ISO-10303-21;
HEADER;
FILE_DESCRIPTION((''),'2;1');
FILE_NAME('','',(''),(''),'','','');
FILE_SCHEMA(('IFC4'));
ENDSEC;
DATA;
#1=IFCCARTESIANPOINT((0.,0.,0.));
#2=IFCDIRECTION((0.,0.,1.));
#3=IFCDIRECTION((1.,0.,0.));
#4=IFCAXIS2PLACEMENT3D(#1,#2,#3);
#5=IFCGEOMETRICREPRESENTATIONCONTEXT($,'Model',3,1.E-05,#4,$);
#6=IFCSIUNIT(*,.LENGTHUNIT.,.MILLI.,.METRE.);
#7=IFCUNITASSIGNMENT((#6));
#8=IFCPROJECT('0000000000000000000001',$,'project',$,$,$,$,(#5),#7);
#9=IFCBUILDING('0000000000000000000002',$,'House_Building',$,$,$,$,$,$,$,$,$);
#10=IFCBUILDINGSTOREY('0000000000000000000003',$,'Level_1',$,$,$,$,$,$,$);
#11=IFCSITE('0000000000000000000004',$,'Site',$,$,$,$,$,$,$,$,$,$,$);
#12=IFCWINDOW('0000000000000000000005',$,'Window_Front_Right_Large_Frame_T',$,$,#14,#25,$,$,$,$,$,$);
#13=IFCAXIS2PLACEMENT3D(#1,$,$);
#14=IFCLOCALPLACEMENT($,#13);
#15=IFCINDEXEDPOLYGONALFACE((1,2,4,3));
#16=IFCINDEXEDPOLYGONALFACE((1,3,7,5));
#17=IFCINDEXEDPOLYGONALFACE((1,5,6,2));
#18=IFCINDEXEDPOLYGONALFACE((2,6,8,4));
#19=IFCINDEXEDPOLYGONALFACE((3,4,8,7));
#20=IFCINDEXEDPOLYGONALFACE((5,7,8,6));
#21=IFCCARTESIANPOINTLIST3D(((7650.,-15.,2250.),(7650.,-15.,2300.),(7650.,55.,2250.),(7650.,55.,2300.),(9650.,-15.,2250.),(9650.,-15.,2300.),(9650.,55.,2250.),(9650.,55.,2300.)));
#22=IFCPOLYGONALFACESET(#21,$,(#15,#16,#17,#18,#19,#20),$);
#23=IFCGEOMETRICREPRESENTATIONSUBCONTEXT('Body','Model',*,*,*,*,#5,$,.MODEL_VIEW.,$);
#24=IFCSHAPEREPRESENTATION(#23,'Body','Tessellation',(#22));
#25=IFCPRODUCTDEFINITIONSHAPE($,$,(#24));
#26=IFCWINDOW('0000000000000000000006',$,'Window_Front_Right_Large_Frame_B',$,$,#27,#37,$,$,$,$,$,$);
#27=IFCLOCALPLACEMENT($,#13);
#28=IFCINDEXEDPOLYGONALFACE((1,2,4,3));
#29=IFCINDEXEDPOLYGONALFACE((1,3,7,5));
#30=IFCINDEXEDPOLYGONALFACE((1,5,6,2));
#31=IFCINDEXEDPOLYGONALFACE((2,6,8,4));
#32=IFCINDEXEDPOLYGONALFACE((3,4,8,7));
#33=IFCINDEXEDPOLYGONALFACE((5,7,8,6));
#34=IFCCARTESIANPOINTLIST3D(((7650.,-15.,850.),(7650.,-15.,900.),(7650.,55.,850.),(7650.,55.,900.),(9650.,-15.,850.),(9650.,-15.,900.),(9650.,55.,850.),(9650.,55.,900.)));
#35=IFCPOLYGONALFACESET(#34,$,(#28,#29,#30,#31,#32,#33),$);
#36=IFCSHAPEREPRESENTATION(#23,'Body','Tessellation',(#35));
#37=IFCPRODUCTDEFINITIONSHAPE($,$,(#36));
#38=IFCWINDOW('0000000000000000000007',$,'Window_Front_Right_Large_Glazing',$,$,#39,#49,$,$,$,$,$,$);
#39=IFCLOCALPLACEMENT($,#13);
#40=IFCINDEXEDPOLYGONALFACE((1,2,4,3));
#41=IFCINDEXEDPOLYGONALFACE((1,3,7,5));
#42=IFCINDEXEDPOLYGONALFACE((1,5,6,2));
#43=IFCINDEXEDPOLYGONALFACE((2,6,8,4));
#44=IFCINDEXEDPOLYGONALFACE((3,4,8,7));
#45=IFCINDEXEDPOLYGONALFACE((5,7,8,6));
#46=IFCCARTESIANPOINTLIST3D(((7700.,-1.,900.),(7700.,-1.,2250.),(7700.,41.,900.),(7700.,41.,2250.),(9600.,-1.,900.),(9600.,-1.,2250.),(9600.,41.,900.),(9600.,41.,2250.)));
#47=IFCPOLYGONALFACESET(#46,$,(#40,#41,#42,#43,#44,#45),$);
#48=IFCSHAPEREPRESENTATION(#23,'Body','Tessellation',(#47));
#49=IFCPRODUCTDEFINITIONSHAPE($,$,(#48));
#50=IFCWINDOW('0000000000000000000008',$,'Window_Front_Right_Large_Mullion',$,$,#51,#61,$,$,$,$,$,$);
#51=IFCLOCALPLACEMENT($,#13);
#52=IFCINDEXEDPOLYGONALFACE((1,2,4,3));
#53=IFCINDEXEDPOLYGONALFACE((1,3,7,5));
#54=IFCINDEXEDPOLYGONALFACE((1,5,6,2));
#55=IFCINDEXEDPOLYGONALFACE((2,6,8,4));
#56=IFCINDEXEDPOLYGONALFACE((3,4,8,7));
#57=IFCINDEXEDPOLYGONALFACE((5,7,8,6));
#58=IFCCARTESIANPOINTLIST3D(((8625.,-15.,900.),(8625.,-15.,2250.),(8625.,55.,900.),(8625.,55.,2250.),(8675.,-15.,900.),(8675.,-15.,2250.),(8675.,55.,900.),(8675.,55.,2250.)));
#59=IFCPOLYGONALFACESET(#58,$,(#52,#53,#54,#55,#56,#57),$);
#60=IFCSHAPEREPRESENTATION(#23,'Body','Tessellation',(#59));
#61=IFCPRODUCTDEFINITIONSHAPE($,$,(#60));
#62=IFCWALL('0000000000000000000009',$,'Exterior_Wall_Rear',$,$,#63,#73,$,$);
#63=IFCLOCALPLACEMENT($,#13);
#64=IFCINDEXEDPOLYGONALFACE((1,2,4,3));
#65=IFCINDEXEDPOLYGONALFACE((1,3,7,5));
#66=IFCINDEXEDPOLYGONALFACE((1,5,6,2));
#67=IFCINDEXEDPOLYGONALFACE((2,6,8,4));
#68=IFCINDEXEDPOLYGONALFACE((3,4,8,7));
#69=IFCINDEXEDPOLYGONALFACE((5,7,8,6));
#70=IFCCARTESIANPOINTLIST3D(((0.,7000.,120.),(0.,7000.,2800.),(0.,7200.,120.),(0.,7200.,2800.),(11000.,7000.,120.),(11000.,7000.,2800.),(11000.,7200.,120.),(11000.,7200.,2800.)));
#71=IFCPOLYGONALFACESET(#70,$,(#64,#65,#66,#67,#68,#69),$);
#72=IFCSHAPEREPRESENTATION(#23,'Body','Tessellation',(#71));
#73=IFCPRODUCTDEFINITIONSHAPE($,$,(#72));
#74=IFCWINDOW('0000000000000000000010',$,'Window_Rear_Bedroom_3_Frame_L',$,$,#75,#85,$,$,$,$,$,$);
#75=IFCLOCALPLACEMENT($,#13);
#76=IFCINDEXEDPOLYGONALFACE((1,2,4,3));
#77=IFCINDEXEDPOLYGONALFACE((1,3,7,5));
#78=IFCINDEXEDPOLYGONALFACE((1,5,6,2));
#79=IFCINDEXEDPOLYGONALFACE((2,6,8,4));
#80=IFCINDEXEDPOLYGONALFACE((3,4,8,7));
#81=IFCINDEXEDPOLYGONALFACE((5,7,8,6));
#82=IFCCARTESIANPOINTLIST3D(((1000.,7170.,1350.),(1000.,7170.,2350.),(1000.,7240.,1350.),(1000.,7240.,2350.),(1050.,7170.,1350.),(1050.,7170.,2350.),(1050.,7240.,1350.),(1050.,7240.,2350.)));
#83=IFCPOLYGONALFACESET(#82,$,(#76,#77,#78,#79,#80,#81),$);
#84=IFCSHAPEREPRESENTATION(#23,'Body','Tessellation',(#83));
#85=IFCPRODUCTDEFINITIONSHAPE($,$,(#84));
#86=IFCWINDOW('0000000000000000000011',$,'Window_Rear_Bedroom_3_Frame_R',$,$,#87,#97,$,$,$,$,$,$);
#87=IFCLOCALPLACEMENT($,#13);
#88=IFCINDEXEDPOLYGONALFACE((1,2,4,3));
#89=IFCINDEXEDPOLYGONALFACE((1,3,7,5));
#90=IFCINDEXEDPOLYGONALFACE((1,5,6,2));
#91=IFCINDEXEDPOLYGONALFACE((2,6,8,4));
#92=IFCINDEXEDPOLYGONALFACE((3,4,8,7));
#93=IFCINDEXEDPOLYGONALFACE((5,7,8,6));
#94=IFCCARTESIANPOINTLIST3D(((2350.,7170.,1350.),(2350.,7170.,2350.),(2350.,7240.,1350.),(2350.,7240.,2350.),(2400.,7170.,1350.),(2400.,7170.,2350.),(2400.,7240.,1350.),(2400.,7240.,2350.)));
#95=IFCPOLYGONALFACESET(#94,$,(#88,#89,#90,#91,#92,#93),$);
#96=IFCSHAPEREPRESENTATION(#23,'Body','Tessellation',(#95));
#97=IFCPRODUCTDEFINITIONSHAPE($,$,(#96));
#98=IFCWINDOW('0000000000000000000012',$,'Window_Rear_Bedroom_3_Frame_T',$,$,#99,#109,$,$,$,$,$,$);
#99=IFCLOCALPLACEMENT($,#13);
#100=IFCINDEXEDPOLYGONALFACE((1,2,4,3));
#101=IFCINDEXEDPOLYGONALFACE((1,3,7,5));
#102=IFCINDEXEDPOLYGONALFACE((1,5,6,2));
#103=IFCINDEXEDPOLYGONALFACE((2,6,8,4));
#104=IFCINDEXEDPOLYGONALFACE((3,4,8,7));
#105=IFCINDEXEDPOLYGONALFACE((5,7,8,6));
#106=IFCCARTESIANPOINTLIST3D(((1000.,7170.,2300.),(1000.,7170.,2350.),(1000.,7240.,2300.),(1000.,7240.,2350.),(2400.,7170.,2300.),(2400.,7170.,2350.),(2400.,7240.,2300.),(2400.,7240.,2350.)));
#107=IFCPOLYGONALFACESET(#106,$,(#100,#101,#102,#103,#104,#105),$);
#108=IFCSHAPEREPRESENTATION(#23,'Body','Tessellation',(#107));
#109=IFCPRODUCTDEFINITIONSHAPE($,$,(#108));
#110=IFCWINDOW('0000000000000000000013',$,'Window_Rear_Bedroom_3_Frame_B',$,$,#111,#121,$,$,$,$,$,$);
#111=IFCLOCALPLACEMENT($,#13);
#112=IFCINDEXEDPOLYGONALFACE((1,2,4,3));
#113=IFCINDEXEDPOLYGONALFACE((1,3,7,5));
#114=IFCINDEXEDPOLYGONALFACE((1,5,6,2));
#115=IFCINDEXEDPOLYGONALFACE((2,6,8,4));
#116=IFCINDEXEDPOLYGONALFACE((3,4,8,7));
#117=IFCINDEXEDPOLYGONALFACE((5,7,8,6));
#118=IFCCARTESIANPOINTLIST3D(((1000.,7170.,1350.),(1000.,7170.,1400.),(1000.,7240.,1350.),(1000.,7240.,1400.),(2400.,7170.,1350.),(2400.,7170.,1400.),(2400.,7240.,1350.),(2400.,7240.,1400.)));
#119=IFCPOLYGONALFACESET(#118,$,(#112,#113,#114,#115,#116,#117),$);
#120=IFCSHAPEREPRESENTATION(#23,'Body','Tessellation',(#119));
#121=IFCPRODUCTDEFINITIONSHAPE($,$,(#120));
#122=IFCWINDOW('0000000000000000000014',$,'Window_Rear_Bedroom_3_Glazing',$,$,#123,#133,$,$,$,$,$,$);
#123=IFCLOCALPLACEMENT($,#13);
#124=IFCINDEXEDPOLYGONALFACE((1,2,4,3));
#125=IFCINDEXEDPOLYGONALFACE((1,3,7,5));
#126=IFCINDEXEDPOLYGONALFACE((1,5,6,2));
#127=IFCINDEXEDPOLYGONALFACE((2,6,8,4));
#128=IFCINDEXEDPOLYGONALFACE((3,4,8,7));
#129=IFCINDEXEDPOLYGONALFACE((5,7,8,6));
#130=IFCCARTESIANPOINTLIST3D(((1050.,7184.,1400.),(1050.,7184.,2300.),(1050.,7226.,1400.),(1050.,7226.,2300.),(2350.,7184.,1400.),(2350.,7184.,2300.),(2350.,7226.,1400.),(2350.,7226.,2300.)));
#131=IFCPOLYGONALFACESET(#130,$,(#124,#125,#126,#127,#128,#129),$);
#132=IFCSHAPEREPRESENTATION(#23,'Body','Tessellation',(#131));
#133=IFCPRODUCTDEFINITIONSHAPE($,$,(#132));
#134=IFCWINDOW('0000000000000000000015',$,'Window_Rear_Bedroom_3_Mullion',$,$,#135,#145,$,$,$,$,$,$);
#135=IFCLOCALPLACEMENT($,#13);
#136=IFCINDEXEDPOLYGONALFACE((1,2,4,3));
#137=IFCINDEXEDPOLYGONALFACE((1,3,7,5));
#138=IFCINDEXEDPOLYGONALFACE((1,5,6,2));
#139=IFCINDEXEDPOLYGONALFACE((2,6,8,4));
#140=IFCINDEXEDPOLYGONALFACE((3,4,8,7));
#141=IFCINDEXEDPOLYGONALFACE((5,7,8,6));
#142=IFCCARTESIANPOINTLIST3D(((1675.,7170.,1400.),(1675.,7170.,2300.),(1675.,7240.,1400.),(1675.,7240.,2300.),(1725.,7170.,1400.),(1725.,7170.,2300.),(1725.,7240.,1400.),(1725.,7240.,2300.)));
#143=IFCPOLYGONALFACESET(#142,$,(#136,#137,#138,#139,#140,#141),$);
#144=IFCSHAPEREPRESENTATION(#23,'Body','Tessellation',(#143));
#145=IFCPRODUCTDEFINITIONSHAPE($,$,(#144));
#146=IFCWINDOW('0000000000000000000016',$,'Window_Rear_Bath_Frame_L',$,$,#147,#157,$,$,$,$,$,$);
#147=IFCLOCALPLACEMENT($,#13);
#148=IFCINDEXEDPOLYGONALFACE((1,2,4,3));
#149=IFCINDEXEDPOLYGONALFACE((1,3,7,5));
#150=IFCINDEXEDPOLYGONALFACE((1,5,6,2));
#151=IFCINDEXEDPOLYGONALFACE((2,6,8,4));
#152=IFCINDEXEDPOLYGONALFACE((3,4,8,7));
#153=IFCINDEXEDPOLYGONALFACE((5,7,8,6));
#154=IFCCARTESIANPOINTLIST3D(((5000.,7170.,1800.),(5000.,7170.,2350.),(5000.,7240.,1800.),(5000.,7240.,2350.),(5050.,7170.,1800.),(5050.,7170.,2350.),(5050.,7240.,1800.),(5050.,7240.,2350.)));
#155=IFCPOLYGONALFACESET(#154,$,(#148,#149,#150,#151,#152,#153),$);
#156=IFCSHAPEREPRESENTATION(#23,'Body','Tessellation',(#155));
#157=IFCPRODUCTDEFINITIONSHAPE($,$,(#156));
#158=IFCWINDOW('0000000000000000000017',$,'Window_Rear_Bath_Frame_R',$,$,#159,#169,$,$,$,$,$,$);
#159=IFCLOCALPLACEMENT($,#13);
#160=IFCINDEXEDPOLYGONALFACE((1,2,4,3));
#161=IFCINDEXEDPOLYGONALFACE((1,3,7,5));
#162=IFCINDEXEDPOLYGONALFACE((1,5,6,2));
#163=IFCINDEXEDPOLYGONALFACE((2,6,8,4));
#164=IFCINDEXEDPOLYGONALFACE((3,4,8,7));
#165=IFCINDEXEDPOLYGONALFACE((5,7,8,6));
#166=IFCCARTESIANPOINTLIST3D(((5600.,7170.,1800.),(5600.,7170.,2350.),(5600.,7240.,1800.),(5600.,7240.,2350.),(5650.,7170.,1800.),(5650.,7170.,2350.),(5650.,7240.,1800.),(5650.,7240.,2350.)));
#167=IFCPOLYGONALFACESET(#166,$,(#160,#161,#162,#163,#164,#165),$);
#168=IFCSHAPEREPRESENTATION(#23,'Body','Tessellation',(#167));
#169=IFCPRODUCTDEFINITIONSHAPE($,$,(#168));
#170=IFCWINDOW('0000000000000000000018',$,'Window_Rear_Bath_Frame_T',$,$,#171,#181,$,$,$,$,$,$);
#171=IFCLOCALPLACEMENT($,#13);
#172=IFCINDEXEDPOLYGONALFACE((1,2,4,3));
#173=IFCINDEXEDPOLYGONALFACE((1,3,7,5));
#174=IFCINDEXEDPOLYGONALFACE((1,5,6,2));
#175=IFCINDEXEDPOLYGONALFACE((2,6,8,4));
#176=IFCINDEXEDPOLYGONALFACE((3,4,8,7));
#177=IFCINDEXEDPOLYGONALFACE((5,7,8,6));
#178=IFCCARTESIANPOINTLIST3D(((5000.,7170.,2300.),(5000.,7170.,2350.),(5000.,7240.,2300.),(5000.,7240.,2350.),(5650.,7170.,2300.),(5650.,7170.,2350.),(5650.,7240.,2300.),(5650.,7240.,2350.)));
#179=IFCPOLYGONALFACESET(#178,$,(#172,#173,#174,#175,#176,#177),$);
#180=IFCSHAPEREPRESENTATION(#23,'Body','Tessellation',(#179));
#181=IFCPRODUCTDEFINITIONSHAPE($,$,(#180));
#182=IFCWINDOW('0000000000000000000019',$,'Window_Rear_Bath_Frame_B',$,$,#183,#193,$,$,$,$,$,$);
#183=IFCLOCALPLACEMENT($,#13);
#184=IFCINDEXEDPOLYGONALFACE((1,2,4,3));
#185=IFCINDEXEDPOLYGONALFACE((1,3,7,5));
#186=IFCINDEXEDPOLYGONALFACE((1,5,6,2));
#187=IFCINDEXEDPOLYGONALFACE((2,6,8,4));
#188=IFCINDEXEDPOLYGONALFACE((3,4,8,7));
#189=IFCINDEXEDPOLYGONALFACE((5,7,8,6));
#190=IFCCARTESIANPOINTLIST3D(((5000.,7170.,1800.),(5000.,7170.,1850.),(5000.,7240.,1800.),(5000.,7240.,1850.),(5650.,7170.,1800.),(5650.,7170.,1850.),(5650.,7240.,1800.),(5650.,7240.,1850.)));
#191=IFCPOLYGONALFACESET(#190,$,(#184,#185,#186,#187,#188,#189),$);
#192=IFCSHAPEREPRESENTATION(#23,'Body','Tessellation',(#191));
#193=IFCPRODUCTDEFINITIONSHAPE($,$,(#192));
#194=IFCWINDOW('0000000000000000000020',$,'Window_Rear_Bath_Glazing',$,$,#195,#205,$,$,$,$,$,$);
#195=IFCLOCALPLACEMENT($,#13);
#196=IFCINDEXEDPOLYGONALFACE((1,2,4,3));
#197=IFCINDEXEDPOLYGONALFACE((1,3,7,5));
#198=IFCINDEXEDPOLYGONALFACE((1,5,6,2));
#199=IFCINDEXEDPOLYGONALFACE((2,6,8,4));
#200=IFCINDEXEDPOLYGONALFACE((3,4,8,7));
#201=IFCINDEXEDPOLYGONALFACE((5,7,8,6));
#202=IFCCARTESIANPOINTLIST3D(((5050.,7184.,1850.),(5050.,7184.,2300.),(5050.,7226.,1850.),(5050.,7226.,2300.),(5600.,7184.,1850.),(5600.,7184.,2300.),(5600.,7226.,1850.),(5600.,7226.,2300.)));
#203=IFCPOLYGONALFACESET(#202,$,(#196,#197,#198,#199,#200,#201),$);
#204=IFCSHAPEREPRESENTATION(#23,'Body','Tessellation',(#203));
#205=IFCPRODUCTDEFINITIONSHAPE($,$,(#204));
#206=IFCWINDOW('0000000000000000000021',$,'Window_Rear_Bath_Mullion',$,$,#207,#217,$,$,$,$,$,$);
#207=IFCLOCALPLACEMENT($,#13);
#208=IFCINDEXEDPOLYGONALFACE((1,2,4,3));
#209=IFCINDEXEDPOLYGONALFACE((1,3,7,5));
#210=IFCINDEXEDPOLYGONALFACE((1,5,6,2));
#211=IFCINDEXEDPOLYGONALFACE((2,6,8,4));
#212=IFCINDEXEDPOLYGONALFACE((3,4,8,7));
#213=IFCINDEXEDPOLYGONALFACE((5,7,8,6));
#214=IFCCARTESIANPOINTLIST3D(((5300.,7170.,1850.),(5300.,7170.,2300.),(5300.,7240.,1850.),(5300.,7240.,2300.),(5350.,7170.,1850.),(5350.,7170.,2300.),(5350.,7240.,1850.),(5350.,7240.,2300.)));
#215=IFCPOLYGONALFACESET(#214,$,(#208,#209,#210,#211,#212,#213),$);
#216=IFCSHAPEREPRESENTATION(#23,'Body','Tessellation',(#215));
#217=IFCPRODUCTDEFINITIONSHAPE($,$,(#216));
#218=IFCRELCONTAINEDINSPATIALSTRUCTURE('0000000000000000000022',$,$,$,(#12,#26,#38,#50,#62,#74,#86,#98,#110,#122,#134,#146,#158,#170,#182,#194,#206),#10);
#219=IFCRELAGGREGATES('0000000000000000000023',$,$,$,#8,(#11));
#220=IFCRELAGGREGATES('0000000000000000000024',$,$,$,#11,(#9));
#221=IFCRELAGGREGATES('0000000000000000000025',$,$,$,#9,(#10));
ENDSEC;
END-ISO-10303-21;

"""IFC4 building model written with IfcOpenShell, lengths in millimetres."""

from ifc_helpers import new_model, si_unit, frame, origin_with_axes, context, subcontext, project, spatial, polyline, outline, extrude, element, save


model = new_model("IFC4")

# Units and contexts
model_context = context("Model", 3, precision=1e-05, world=origin_with_axes())
body_context = subcontext(model_context, "Body", "Model", "MODEL_VIEW")
ifc_project = project(units=[si_unit("LENGTHUNIT", "METRE", prefix="MILLI")], contexts=[model_context])

# Site, building, storey
site = spatial("IfcSite", under=ifc_project, Name="Site")
building = spatial("IfcBuilding", under=site, Name="House_Building")
storey = spatial("IfcBuildingStorey", under=building, Name="Level_1")

# Windows
element("IfcWindow", 1, inside=storey, Name="Window_Front_Right_Large_Frame_T", context=body_context, shape_type="SweptSolid", body=[
    extrude(outline(polyline([(7650.0, -15.0), (9650.0, -15.0), (9650.0, 55.0), (7650.0, 55.0), (7650.0, -15.0)])), frame((0.0, 0.0, 2250.0), z_axis=(0.0, 0.0, 1.0), x_axis=(1.0, 0.0, 0.0)), (0.0, 0.0, 1.0), 50.0),
])
element("IfcWindow", 2, inside=storey, Name="Window_Front_Right_Large_Frame_B", context=body_context, shape_type="SweptSolid", body=[
    extrude(outline(polyline([(7650.0, -15.0), (9650.0, -15.0), (9650.0, 55.0), (7650.0, 55.0), (7650.0, -15.0)])), frame((0.0, 0.0, 850.0), z_axis=(0.0, 0.0, 1.0), x_axis=(1.0, 0.0, 0.0)), (0.0, 0.0, 1.0), 50.0),
])
element("IfcWindow", 3, inside=storey, Name="Window_Front_Right_Large_Glazing", context=body_context, shape_type="SweptSolid", body=[
    extrude(outline(polyline([(7700.0, -1.0), (9600.0, -1.0), (9600.0, 41.0), (7700.0, 41.0), (7700.0, -1.0)])), frame((0.0, 0.0, 900.0), z_axis=(0.0, 0.0, 1.0), x_axis=(1.0, 0.0, 0.0)), (0.0, 0.0, 1.0), 1350.0),
])
element("IfcWindow", 4, inside=storey, Name="Window_Front_Right_Large_Mullion", context=body_context, shape_type="SweptSolid", body=[
    extrude(outline(polyline([(8625.0, -15.0), (8675.0, -15.0), (8675.0, 55.0), (8625.0, 55.0), (8625.0, -15.0)])), frame((0.0, 0.0, 900.0), z_axis=(0.0, 0.0, 1.0), x_axis=(1.0, 0.0, 0.0)), (0.0, 0.0, 1.0), 1350.0),
])

# Wall
element("IfcWall", 5, inside=storey, Name="Exterior_Wall_Rear", context=body_context, shape_type="SweptSolid", body=[
    extrude(outline(polyline([(0.0, 7000.0), (11000.0, 7000.0), (11000.0, 7200.0), (0.0, 7200.0), (0.0, 7000.0)])), frame((0.0, 0.0, 120.0), z_axis=(0.0, 0.0, 1.0), x_axis=(1.0, 0.0, 0.0)), (0.0, 0.0, 1.0), 2680.0),
])

# Windows
element("IfcWindow", 6, inside=storey, Name="Window_Rear_Bedroom_3_Frame_L", context=body_context, shape_type="SweptSolid", body=[
    extrude(outline(polyline([(1000.0, 7170.0), (1050.0, 7170.0), (1050.0, 7240.0), (1000.0, 7240.0), (1000.0, 7170.0)])), frame((0.0, 0.0, 1350.0), z_axis=(0.0, 0.0, 1.0), x_axis=(1.0, 0.0, 0.0)), (0.0, 0.0, 1.0), 1000.0),
])
element("IfcWindow", 7, inside=storey, Name="Window_Rear_Bedroom_3_Frame_R", context=body_context, shape_type="SweptSolid", body=[
    extrude(outline(polyline([(2350.0, 7170.0), (2400.0, 7170.0), (2400.0, 7240.0), (2350.0, 7240.0), (2350.0, 7170.0)])), frame((0.0, 0.0, 1350.0), z_axis=(0.0, 0.0, 1.0), x_axis=(1.0, 0.0, 0.0)), (0.0, 0.0, 1.0), 1000.0),
])
element("IfcWindow", 8, inside=storey, Name="Window_Rear_Bedroom_3_Frame_T", context=body_context, shape_type="SweptSolid", body=[
    extrude(outline(polyline([(1000.0, 7170.0), (2400.0, 7170.0), (2400.0, 7240.0), (1000.0, 7240.0), (1000.0, 7170.0)])), frame((0.0, 0.0, 2300.0), z_axis=(0.0, 0.0, 1.0), x_axis=(1.0, 0.0, 0.0)), (0.0, 0.0, 1.0), 50.0),
])
element("IfcWindow", 9, inside=storey, Name="Window_Rear_Bedroom_3_Frame_B", context=body_context, shape_type="SweptSolid", body=[
    extrude(outline(polyline([(1000.0, 7170.0), (2400.0, 7170.0), (2400.0, 7240.0), (1000.0, 7240.0), (1000.0, 7170.0)])), frame((0.0, 0.0, 1350.0), z_axis=(0.0, 0.0, 1.0), x_axis=(1.0, 0.0, 0.0)), (0.0, 0.0, 1.0), 50.0),
])
element("IfcWindow", 10, inside=storey, Name="Window_Rear_Bedroom_3_Glazing", context=body_context, shape_type="SweptSolid", body=[
    extrude(outline(polyline([(1050.0, 7184.0), (2350.0, 7184.0), (2350.0, 7226.0), (1050.0, 7226.0), (1050.0, 7184.0)])), frame((0.0, 0.0, 1400.0), z_axis=(0.0, 0.0, 1.0), x_axis=(1.0, 0.0, 0.0)), (0.0, 0.0, 1.0), 900.0),
])
element("IfcWindow", 11, inside=storey, Name="Window_Rear_Bedroom_3_Mullion", context=body_context, shape_type="SweptSolid", body=[
    extrude(outline(polyline([(1675.0, 7170.0), (1725.0, 7170.0), (1725.0, 7240.0), (1675.0, 7240.0), (1675.0, 7170.0)])), frame((0.0, 0.0, 1400.0), z_axis=(0.0, 0.0, 1.0), x_axis=(1.0, 0.0, 0.0)), (0.0, 0.0, 1.0), 900.0),
])
element("IfcWindow", 12, inside=storey, Name="Window_Rear_Bath_Frame_L", context=body_context, shape_type="SweptSolid", body=[
    extrude(outline(polyline([(5000.0, 7170.0), (5050.0, 7170.0), (5050.0, 7240.0), (5000.0, 7240.0), (5000.0, 7170.0)])), frame((0.0, 0.0, 1800.0), z_axis=(0.0, 0.0, 1.0), x_axis=(1.0, 0.0, 0.0)), (0.0, 0.0, 1.0), 550.0),
])
element("IfcWindow", 13, inside=storey, Name="Window_Rear_Bath_Frame_R", context=body_context, shape_type="SweptSolid", body=[
    extrude(outline(polyline([(5600.0, 7170.0), (5650.0, 7170.0), (5650.0, 7240.0), (5600.0, 7240.0), (5600.0, 7170.0)])), frame((0.0, 0.0, 1800.0), z_axis=(0.0, 0.0, 1.0), x_axis=(1.0, 0.0, 0.0)), (0.0, 0.0, 1.0), 550.0),
])
element("IfcWindow", 14, inside=storey, Name="Window_Rear_Bath_Frame_T", context=body_context, shape_type="SweptSolid", body=[
    extrude(outline(polyline([(5000.0, 7170.0), (5650.0, 7170.0), (5650.0, 7240.0), (5000.0, 7240.0), (5000.0, 7170.0)])), frame((0.0, 0.0, 2300.0), z_axis=(0.0, 0.0, 1.0), x_axis=(1.0, 0.0, 0.0)), (0.0, 0.0, 1.0), 50.0),
])
element("IfcWindow", 15, inside=storey, Name="Window_Rear_Bath_Frame_B", context=body_context, shape_type="SweptSolid", body=[
    extrude(outline(polyline([(5000.0, 7170.0), (5650.0, 7170.0), (5650.0, 7240.0), (5000.0, 7240.0), (5000.0, 7170.0)])), frame((0.0, 0.0, 1800.0), z_axis=(0.0, 0.0, 1.0), x_axis=(1.0, 0.0, 0.0)), (0.0, 0.0, 1.0), 50.0),
])
element("IfcWindow", 16, inside=storey, Name="Window_Rear_Bath_Glazing", context=body_context, shape_type="SweptSolid", body=[
    extrude(outline(polyline([(5050.0, 7184.0), (5600.0, 7184.0), (5600.0, 7226.0), (5050.0, 7226.0), (5050.0, 7184.0)])), frame((0.0, 0.0, 1850.0), z_axis=(0.0, 0.0, 1.0), x_axis=(1.0, 0.0, 0.0)), (0.0, 0.0, 1.0), 450.0),
])
element("IfcWindow", 17, inside=storey, Name="Window_Rear_Bath_Mullion", context=body_context, shape_type="SweptSolid", body=[
    extrude(outline(polyline([(5300.0, 7170.0), (5350.0, 7170.0), (5350.0, 7240.0), (5300.0, 7240.0), (5300.0, 7170.0)])), frame((0.0, 0.0, 1850.0), z_axis=(0.0, 0.0, 1.0), x_axis=(1.0, 0.0, 0.0)), (0.0, 0.0, 1.0), 450.0),
])

save(model, "model.ifc")
